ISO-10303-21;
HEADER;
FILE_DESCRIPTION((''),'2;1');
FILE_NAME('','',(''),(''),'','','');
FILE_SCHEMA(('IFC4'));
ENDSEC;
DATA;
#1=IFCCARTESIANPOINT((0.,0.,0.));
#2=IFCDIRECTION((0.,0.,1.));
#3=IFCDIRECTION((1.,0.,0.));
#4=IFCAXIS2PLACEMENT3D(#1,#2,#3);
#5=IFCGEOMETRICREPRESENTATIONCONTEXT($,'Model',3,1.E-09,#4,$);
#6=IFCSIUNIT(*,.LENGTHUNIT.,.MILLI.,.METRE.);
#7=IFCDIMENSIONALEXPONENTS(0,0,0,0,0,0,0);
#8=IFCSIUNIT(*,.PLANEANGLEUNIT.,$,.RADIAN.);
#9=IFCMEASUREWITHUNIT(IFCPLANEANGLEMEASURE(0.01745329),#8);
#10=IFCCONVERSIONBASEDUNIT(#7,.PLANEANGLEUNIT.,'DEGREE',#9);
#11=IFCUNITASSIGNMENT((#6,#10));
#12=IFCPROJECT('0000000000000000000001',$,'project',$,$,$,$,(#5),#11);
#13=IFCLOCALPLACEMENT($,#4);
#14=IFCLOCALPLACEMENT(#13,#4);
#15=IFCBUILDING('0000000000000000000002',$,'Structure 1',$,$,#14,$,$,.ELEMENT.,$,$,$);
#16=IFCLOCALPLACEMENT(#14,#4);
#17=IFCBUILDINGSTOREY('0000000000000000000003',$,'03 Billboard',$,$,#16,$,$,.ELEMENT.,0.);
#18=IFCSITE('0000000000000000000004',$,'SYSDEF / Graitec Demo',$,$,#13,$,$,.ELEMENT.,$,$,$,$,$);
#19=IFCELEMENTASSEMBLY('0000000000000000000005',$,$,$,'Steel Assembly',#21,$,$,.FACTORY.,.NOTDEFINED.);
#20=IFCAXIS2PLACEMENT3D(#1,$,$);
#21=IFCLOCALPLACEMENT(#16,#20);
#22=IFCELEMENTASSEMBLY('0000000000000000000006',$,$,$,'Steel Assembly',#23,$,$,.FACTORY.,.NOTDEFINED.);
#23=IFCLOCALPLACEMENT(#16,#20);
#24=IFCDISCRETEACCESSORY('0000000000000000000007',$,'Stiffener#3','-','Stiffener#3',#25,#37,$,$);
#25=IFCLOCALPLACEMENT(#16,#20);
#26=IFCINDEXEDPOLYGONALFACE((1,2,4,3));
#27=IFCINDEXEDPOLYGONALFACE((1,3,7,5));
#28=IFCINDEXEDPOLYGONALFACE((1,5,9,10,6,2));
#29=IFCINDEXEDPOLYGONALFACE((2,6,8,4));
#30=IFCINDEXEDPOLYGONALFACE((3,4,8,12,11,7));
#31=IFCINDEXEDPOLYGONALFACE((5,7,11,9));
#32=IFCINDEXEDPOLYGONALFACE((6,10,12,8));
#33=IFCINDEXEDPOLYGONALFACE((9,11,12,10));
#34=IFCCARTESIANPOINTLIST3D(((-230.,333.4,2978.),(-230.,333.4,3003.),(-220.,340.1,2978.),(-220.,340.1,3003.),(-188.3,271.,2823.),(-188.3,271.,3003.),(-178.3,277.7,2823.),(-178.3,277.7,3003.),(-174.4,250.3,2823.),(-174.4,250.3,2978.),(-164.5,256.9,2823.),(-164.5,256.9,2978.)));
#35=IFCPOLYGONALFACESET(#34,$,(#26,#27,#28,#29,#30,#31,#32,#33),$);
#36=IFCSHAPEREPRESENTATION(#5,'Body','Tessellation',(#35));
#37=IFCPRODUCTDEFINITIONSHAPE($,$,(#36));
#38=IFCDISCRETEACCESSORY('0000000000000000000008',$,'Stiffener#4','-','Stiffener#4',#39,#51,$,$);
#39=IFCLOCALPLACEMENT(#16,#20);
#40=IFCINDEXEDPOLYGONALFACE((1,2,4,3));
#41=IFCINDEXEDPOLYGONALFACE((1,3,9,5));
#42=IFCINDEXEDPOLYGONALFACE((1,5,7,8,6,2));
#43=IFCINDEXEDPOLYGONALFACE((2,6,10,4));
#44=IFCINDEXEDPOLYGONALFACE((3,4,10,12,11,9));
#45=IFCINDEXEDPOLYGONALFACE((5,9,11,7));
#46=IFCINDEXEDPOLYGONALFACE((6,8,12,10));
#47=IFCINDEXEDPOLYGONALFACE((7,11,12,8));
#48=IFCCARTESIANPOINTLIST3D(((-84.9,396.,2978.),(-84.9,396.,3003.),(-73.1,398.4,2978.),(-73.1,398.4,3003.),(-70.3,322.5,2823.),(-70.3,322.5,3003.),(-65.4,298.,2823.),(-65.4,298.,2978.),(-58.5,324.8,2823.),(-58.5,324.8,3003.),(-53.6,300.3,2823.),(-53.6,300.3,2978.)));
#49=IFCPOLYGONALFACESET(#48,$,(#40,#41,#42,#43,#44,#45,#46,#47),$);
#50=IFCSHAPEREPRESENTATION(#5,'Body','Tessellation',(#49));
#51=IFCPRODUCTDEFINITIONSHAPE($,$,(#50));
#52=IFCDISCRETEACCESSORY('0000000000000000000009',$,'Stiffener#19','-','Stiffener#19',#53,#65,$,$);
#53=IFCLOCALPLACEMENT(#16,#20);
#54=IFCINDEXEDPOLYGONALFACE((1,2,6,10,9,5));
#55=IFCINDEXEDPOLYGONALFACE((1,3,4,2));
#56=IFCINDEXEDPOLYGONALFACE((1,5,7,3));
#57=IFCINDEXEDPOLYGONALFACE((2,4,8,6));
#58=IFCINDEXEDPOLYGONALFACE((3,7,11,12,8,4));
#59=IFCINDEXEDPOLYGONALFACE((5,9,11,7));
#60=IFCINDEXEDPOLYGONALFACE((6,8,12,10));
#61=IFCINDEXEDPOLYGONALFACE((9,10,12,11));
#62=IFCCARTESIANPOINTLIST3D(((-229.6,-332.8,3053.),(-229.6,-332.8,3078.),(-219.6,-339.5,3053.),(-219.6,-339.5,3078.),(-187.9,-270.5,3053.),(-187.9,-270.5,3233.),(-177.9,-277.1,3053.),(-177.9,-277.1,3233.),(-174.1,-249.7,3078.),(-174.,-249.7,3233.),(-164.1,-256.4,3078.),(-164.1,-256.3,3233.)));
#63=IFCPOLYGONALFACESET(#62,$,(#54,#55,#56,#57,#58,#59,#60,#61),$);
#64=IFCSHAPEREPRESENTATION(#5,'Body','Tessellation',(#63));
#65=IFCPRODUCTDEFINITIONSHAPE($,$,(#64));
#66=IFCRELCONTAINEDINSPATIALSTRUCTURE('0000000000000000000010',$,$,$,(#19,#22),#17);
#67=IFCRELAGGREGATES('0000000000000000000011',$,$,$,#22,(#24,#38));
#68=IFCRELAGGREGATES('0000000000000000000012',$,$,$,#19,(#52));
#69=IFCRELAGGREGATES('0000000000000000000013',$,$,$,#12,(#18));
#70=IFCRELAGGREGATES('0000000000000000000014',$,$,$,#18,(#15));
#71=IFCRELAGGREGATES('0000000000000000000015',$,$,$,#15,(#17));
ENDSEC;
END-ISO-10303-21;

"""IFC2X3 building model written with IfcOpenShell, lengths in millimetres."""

from ifc_helpers import new_model, entity, si_unit, converted_unit, frame, origin, origin_with_axes, place, context, project, spatial, polyline, outline, extrude, element, aggregate, save


model = new_model("IFC2X3")

# Units and contexts
model_context = context("Model", 3, precision=1e-09, world=origin_with_axes())
ifc_project = project(units=[si_unit("LENGTHUNIT", "METRE", prefix="MILLI"), converted_unit("PLANEANGLEUNIT", "DEGREE", entity("IfcPlaneAngleMeasure", 0.01745329), si_unit("PLANEANGLEUNIT", "RADIAN"), dimensions=[0, 0, 0, 0, 0, 0, 0])], contexts=[model_context])

# Site, building, storey
site_placement = place(None, origin_with_axes())
site = spatial("IfcSite", under=ifc_project, at=site_placement, Name="SYSDEF / Graitec Demo", CompositionType="ELEMENT")
building_placement = place(site_placement, origin_with_axes())
building = spatial("IfcBuilding", under=site, at=building_placement, Name="Structure 1", CompositionType="ELEMENT")
storey_placement = place(building_placement, origin_with_axes())
storey = spatial("IfcBuildingStorey", under=building, at=storey_placement, Name="03 Billboard", CompositionType="ELEMENT", Elevation=0.0)

# Element assembly
assembly_1_placement = place(None, frame((-4406.3, 0.0, 3558.0), z_axis=(-1.0, 0.0, 0.0), x_axis=(0.0, -1.0, 0.0)))
assembly_1 = element("IfcElementAssembly", 1, at=assembly_1_placement, inside=storey, ObjectType="Steel Assembly", AssemblyPlace="FACTORY", PredefinedType="NOTDEFINED")

# Element assembly, discrete accessories, openings
assembly_2_placement = place(None, frame((0.0, 0.0, 43.7), z_axis=(0.0, 0.0, -1.0), x_axis=(0.0, 1.0, 0.0)))
assembly_2 = element("IfcElementAssembly", 2, at=assembly_2_placement, inside=storey, ObjectType="Steel Assembly", AssemblyPlace="FACTORY", PredefinedType="NOTDEFINED")
discrete_accessory_1_placement = place(assembly_2_placement, frame((250.3, -174.4, -2959.3), z_axis=(0.55557, 0.83147, 0.0), x_axis=(0.0, 0.0, 1.0)))
discrete_accessory_1 = element("IfcDiscreteAccessory", 3, at=discrete_accessory_1_placement, Name="Stiffener#3", Description="-", ObjectType="Stiffener#3", context=model_context, shape_type="SweptSolid", body=[
    extrude(outline(polyline([(0.0, 0.0), (180.0, 0.0), (180.0, 100.0), (0.0, 100.0), (0.0, 0.0)])), origin_with_axes(), (0.0, 0.0, 1.0), 12.0),
])
opening_1_placement = place(discrete_accessory_1_placement, frame((0.0, 0.0, 0.0), z_axis=(0.0, 0.0, 1.0), x_axis=(1.0, 0.0, 0.0)))
element("IfcOpeningElement", 4, at=opening_1_placement, cuts=discrete_accessory_1, ObjectType="Opening", context=model_context, shape_type="SweptSolid", body=[
    extrude(outline(polyline([(180.0, 100.0), (25.0, 100.0), (180.0, 25.0), (180.0, 100.0)])), origin(), (0.0, 0.0, 1.0), 12.0),
])
opening_2_placement = place(discrete_accessory_1_placement, frame((0.0, 0.0, 0.0), z_axis=(0.0, 0.0, 1.0), x_axis=(1.0, 0.0, 0.0)))
element("IfcOpeningElement", 5, at=opening_2_placement, cuts=discrete_accessory_1, ObjectType="Opening", context=model_context, shape_type="SweptSolid", body=[
    extrude(outline(polyline([(0.0, 0.0), (25.0, 0.0), (0.0, 25.0), (0.0, 0.0)])), origin(), (0.0, 0.0, 1.0), 12.0),
])
discrete_accessory_2_placement = place(assembly_2_placement, frame((298.0, -65.4, -2959.3), z_axis=(0.19509, 0.980785, 0.0), x_axis=(0.0, 0.0, 1.0)))
discrete_accessory_2 = element("IfcDiscreteAccessory", 6, at=discrete_accessory_2_placement, Name="Stiffener#4", Description="-", ObjectType="Stiffener#4", context=model_context, shape_type="SweptSolid", body=[
    extrude(outline(polyline([(0.0, 0.0), (180.0, 0.0), (180.0, 100.0), (0.0, 100.0), (0.0, 0.0)])), origin_with_axes(), (0.0, 0.0, 1.0), 12.0),
])
opening_3_placement = place(discrete_accessory_2_placement, frame((0.0, 0.0, 0.0), z_axis=(0.0, 0.0, 1.0), x_axis=(1.0, 0.0, 0.0)))
element("IfcOpeningElement", 7, at=opening_3_placement, cuts=discrete_accessory_2, ObjectType="Opening", context=model_context, shape_type="SweptSolid", body=[
    extrude(outline(polyline([(180.0, 100.0), (25.0, 100.0), (180.0, 25.0), (180.0, 100.0)])), origin(), (0.0, 0.0, 1.0), 12.0),
])
opening_4_placement = place(discrete_accessory_2_placement, frame((0.0, 0.0, 0.0), z_axis=(0.0, 0.0, 1.0), x_axis=(1.0, 0.0, 0.0)))
element("IfcOpeningElement", 8, at=opening_4_placement, cuts=discrete_accessory_2, ObjectType="Opening", context=model_context, shape_type="SweptSolid", body=[
    extrude(outline(polyline([(0.0, 0.0), (25.0, 0.0), (0.0, 25.0), (0.0, 0.0)])), origin(), (0.0, 0.0, 1.0), 12.0),
])
aggregate(assembly_2, [discrete_accessory_1, discrete_accessory_2])

# Discrete accessory, openings
discrete_accessory_3_placement = place(assembly_1_placement, frame((249.7, -505.0, -4232.3), z_axis=(0.55557, 0.0, -0.83147), x_axis=(0.0, 1.0, 0.0)))
discrete_accessory_3 = element("IfcDiscreteAccessory", 9, at=discrete_accessory_3_placement, Name="Stiffener#19", Description="-", ObjectType="Stiffener#19", context=model_context, shape_type="SweptSolid", body=[
    extrude(outline(polyline([(0.0, 0.0), (180.0, 0.0), (180.0, 100.0), (0.0, 100.0), (0.0, 0.0)])), origin_with_axes(), (0.0, 0.0, 1.0), 12.0),
])
opening_5_placement = place(discrete_accessory_3_placement, frame((0.0, 0.0, 0.0), z_axis=(0.0, 0.0, 1.0), x_axis=(1.0, 0.0, 0.0)))
element("IfcOpeningElement", 10, at=opening_5_placement, cuts=discrete_accessory_3, ObjectType="Opening", context=model_context, shape_type="SweptSolid", body=[
    extrude(outline(polyline([(180.0, 100.0), (25.0, 100.0), (180.0, 25.0), (180.0, 100.0)])), origin(), (0.0, 0.0, 1.0), 12.0),
])
opening_6_placement = place(discrete_accessory_3_placement, frame((0.0, 0.0, 0.0), z_axis=(0.0, 0.0, 1.0), x_axis=(1.0, 0.0, 0.0)))
element("IfcOpeningElement", 11, at=opening_6_placement, cuts=discrete_accessory_3, ObjectType="Opening", context=model_context, shape_type="SweptSolid", body=[
    extrude(outline(polyline([(0.0, 0.0), (25.0, 0.0), (0.0, 25.0), (0.0, 0.0)])), origin(), (0.0, 0.0, 1.0), 12.0),
])
aggregate(assembly_1, [discrete_accessory_3])

save(model, "model.ifc")
